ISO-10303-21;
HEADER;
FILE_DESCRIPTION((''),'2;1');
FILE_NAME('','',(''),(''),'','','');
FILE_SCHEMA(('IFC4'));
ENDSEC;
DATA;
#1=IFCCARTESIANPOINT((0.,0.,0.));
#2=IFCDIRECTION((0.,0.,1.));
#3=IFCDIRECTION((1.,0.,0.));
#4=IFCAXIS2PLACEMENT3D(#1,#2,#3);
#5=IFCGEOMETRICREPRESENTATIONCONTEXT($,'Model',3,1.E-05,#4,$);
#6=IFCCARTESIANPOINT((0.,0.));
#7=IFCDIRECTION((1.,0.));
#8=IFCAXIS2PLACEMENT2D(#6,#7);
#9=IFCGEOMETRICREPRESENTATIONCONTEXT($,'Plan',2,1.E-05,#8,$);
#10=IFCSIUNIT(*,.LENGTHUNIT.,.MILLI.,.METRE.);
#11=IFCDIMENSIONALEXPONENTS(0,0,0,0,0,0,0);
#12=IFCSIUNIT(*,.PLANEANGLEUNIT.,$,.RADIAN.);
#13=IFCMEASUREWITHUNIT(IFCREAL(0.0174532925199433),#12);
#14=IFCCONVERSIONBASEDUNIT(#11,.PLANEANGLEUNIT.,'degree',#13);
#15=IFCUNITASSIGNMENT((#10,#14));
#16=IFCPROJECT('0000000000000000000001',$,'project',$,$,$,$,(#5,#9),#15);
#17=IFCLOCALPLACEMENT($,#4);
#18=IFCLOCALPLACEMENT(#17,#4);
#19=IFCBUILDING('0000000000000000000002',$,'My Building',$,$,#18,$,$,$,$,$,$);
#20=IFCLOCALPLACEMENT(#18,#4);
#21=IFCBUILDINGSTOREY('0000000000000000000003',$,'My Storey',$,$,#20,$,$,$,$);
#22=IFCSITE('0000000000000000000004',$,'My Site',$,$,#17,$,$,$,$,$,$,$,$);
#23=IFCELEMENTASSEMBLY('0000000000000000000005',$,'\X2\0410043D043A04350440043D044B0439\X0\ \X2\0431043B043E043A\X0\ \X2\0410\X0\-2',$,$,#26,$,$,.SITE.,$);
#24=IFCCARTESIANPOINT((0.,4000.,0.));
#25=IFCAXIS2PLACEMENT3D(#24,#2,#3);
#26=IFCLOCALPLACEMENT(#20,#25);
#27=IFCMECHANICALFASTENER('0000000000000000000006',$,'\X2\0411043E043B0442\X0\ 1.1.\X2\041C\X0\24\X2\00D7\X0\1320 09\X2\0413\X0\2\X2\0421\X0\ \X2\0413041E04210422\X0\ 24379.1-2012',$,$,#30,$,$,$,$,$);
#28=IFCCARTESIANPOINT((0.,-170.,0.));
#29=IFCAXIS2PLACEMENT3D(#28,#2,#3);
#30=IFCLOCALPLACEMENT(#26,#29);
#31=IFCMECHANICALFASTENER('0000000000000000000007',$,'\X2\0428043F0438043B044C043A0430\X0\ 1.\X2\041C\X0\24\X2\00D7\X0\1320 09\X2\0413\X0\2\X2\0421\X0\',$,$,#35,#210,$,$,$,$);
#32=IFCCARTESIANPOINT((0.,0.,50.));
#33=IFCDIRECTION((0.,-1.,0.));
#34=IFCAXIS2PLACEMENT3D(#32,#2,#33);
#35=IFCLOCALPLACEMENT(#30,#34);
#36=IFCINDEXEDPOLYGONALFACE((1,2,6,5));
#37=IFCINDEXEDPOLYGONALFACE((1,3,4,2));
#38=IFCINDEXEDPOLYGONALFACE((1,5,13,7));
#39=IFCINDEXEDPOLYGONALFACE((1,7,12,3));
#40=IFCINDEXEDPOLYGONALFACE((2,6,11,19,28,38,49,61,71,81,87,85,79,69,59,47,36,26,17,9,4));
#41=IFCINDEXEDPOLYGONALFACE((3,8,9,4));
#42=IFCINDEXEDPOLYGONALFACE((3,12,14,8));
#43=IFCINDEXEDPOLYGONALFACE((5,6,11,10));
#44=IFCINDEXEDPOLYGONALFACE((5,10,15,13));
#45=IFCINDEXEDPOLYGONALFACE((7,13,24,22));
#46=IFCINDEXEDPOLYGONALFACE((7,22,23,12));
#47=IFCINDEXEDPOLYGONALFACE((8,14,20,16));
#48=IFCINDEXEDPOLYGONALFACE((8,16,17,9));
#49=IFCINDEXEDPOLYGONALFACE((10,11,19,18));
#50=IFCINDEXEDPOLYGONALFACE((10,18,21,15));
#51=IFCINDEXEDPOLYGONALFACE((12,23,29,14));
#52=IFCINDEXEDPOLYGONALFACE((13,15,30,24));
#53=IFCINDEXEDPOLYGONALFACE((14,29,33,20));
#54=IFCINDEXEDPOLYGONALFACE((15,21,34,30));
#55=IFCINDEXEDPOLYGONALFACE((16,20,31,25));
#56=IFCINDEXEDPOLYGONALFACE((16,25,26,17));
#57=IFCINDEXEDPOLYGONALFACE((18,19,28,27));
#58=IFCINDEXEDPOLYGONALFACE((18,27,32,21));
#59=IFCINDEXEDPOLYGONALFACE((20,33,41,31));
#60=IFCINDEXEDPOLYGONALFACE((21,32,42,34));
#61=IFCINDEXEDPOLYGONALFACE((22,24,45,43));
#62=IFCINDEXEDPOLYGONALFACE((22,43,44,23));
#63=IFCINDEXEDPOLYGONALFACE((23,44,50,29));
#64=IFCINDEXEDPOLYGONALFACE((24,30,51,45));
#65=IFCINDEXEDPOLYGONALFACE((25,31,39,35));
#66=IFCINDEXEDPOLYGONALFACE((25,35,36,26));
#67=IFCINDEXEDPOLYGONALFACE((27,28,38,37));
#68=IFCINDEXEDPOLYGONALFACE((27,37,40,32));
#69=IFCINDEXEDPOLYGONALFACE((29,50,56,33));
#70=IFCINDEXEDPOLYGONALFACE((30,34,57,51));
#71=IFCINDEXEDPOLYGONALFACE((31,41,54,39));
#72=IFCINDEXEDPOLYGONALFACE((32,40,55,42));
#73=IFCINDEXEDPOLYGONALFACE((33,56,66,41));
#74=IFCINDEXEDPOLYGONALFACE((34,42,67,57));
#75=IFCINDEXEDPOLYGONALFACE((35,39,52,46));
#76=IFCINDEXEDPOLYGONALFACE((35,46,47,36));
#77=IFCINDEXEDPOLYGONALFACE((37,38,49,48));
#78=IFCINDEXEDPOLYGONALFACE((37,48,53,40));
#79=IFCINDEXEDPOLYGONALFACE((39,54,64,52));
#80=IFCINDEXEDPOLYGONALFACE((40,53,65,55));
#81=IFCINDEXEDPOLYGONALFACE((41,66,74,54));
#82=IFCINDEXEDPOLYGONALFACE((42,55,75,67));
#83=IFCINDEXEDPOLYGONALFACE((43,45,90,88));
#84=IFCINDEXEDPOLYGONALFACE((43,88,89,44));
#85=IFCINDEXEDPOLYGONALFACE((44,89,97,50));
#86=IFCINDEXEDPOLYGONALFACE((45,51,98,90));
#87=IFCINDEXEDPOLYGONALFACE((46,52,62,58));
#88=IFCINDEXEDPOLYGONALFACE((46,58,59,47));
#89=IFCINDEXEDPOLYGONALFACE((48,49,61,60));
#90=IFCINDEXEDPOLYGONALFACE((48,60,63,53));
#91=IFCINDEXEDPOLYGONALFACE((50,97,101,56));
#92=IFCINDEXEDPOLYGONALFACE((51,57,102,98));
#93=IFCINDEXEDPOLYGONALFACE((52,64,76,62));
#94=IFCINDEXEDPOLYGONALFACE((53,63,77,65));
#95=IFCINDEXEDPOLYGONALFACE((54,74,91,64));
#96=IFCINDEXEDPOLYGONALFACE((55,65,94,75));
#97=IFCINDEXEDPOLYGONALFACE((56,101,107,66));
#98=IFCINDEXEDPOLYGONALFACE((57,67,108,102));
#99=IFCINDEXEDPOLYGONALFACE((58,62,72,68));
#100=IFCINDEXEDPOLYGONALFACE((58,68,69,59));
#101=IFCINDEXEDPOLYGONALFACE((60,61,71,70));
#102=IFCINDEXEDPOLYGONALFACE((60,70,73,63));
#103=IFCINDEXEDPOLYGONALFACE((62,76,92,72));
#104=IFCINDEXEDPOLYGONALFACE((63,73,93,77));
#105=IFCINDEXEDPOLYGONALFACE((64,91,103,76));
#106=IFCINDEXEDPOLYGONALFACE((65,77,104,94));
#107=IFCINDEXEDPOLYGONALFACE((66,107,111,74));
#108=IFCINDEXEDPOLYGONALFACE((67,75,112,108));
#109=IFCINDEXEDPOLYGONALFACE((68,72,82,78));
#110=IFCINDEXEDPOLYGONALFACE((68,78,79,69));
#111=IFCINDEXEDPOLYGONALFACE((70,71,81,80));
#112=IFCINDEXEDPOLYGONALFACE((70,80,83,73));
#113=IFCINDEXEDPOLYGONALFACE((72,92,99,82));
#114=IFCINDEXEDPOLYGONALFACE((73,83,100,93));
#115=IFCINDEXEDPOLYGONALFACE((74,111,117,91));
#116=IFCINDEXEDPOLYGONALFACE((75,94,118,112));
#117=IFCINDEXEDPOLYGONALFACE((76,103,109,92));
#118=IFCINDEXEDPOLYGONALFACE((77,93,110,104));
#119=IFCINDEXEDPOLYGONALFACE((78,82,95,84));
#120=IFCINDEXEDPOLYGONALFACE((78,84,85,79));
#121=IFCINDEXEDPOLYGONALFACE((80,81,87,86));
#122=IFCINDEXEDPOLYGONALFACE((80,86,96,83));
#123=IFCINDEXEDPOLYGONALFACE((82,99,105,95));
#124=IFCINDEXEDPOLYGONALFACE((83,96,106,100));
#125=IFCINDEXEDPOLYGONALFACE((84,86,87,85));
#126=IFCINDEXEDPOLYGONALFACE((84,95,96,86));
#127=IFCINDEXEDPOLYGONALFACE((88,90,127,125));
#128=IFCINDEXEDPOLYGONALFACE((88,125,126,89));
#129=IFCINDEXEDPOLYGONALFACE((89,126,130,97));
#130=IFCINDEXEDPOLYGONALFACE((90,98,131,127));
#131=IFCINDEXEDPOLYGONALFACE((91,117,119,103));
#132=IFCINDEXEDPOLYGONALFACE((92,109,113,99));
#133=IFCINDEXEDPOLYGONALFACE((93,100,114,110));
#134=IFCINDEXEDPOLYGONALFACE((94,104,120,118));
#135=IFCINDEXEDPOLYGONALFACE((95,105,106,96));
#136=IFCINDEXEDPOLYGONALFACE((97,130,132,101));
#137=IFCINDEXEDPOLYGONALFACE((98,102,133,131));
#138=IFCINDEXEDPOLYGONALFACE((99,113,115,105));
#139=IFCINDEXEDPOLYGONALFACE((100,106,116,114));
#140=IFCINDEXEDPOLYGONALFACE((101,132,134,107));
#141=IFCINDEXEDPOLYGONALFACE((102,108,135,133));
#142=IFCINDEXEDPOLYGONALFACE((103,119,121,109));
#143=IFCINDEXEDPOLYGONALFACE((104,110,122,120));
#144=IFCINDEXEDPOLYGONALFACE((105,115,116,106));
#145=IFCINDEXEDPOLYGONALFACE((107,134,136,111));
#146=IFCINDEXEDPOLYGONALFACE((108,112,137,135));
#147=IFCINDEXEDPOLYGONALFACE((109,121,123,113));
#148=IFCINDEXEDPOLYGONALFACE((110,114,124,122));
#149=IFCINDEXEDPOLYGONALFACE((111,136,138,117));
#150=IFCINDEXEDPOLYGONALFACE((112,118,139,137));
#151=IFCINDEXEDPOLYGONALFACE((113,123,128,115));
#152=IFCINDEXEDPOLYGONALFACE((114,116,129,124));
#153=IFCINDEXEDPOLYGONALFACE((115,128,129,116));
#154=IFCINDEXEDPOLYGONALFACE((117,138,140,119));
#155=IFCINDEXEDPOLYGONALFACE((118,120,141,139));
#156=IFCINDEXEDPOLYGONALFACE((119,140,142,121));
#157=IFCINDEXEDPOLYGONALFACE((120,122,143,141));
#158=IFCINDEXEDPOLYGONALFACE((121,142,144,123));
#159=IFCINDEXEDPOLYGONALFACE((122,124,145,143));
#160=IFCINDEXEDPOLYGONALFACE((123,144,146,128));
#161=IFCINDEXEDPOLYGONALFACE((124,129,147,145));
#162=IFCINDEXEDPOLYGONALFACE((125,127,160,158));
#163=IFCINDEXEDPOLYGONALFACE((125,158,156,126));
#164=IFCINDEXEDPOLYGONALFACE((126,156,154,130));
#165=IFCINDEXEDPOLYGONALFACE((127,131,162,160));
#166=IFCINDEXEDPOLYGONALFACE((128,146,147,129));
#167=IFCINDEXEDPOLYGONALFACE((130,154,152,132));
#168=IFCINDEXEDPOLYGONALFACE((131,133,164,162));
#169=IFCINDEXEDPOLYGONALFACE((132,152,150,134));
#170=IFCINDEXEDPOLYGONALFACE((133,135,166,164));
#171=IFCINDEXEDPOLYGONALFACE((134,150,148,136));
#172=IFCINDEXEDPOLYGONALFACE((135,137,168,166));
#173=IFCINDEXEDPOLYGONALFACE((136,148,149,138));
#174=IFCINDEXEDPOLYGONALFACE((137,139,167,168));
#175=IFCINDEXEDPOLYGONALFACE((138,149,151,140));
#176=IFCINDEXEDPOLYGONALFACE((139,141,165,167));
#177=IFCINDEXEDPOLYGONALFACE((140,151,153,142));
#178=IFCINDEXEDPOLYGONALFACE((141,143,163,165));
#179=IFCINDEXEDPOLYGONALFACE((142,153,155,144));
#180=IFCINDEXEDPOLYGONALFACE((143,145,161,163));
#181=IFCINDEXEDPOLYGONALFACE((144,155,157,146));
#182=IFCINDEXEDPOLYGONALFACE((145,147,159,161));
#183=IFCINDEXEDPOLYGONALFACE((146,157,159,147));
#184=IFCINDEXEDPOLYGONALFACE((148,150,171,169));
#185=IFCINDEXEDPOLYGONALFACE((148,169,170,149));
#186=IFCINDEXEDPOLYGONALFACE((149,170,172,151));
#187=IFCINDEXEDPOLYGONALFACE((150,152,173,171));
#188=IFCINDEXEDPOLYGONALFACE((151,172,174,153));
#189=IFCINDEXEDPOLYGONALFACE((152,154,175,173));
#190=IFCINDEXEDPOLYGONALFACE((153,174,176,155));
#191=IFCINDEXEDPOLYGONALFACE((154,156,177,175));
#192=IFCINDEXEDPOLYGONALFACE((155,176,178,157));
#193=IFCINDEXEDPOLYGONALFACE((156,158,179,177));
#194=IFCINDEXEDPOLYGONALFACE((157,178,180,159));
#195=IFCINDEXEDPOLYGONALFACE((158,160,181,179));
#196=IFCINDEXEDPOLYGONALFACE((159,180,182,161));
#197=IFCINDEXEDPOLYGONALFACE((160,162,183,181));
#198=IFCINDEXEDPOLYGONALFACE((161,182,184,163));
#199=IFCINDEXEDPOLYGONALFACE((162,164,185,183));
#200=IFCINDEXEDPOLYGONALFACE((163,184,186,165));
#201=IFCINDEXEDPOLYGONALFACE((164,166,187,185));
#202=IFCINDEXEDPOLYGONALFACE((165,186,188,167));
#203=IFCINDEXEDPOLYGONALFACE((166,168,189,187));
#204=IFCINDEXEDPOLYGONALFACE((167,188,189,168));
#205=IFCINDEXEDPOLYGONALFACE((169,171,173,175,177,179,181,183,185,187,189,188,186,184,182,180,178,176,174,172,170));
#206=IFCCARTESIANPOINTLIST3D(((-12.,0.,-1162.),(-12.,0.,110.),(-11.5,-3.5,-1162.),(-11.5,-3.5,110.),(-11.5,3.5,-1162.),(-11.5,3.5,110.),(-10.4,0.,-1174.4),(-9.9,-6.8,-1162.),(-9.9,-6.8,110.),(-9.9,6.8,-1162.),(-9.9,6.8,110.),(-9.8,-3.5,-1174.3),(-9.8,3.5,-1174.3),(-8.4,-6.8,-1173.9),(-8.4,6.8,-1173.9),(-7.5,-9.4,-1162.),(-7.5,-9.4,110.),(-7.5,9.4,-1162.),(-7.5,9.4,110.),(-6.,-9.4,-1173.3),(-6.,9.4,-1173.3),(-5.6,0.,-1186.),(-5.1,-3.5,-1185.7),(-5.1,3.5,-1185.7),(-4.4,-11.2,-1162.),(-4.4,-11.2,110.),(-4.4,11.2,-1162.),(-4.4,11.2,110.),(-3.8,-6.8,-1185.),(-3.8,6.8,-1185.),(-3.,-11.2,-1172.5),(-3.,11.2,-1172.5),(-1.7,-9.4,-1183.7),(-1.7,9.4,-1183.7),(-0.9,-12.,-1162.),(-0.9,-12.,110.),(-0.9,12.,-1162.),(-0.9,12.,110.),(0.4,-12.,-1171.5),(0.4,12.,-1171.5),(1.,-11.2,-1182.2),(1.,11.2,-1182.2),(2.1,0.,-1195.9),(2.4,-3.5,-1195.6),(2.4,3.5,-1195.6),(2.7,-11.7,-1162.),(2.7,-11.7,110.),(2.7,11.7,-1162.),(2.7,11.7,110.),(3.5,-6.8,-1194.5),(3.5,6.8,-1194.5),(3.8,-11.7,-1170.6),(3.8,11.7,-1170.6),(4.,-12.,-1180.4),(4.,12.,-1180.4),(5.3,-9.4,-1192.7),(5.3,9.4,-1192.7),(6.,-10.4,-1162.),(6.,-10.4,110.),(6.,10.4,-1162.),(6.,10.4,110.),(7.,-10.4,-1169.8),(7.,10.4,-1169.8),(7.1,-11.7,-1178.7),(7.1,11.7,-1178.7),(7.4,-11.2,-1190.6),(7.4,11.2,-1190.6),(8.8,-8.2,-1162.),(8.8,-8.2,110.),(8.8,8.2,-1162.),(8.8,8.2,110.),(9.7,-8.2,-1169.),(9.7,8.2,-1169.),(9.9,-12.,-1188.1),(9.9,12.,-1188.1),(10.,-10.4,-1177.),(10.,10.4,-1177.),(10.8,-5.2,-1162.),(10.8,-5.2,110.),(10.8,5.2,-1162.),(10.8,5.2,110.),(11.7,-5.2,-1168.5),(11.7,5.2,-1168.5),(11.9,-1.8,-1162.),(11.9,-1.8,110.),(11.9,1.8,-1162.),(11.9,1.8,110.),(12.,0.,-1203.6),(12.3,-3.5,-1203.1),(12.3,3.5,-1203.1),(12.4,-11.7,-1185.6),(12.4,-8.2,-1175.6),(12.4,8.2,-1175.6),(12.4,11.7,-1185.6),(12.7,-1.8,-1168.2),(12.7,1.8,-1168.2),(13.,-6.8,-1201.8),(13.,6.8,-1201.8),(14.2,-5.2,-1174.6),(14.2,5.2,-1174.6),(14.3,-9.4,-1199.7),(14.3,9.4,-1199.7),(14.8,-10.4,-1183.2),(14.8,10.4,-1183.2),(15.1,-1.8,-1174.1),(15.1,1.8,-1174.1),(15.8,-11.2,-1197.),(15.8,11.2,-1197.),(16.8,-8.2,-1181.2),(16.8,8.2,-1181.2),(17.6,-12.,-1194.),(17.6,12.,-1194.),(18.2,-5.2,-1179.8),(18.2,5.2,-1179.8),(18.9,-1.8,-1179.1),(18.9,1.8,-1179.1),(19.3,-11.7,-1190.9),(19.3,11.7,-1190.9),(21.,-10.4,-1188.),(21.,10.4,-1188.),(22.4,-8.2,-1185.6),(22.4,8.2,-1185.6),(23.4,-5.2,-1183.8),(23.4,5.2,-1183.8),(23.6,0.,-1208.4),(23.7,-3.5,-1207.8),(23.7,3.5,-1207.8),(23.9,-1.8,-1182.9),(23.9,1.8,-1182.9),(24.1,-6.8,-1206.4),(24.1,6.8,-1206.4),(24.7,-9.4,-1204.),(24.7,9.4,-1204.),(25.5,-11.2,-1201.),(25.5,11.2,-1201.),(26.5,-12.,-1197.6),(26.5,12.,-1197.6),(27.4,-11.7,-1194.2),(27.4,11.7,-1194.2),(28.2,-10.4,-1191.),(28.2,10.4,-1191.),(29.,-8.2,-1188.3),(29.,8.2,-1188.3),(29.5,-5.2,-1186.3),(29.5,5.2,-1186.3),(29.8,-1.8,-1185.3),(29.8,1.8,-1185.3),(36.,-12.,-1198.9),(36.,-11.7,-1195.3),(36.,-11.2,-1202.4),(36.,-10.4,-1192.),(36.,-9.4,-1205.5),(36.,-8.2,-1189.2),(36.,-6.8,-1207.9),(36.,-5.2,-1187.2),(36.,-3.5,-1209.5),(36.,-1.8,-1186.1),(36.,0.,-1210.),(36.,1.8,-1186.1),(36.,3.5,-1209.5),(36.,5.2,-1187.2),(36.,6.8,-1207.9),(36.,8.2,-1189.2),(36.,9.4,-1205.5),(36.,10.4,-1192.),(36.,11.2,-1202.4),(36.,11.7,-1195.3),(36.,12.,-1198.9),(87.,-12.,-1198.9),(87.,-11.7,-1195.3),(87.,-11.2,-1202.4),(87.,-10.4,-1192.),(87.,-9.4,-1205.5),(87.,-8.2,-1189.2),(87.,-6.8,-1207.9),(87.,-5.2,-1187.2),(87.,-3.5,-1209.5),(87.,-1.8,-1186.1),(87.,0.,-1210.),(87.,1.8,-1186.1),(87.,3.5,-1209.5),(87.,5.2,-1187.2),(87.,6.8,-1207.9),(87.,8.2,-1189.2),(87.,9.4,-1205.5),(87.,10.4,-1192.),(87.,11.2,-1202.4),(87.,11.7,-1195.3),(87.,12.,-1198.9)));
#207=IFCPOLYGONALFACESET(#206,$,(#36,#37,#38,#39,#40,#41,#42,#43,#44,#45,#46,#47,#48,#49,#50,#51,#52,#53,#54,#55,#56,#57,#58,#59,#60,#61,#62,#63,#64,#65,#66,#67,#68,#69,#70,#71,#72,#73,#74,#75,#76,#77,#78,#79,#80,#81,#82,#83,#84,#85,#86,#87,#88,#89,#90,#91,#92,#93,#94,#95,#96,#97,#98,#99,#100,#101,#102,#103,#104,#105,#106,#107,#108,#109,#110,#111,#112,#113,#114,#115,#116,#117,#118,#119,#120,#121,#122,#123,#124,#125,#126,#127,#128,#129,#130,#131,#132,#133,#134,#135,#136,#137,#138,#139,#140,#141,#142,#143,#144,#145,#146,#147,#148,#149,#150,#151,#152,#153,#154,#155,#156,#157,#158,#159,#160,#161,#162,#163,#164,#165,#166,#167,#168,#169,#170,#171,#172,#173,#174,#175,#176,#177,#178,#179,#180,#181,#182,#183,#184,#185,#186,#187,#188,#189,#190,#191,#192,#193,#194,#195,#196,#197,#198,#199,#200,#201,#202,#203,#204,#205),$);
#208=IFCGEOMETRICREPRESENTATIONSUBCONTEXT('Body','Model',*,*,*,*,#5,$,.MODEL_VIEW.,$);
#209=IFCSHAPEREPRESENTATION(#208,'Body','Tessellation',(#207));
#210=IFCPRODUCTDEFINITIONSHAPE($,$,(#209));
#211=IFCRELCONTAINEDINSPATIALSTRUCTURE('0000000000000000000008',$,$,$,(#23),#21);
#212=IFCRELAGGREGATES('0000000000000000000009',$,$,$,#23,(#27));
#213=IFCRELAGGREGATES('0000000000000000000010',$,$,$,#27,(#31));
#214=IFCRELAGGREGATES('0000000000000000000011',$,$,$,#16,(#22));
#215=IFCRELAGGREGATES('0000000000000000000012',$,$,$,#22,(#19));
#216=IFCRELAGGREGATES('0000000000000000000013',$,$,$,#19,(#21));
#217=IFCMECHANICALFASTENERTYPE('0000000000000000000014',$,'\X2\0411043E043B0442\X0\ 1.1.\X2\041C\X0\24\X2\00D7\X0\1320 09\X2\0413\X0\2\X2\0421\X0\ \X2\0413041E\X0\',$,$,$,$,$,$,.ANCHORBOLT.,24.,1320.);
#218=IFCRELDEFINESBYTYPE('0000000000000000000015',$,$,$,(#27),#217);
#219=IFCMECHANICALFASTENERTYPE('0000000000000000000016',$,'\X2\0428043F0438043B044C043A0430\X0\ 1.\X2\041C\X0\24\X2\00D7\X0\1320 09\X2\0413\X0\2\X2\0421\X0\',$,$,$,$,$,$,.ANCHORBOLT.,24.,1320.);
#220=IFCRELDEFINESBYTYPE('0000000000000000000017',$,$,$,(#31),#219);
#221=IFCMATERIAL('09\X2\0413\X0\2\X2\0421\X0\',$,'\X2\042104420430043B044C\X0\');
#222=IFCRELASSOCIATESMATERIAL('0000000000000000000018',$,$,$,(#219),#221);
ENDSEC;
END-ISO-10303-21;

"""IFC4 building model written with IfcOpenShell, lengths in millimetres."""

from ifc_helpers import new_model, entity, si_unit, converted_unit, frame, origin_with_axes, origin_2d_with_axis, place, context, subcontext, project, spatial, source, transform, mapped, material, type_object, type_shapes, element, aggregate, save


model = new_model("IFC4")

# Units and contexts
model_context = context("Model", 3, precision=1e-05, world=origin_with_axes())
plan_context = context("Plan", 2, precision=1e-05, world=origin_2d_with_axis())
body_context = subcontext(model_context, "Body", "Model", "MODEL_VIEW")
ifc_project = project(units=[si_unit("LENGTHUNIT", "METRE", prefix="MILLI"), converted_unit("PLANEANGLEUNIT", "degree", entity("IfcReal", 0.0174532925199433), si_unit("PLANEANGLEUNIT", "RADIAN"), dimensions=[0, 0, 0, 0, 0, 0, 0])], contexts=[model_context, plan_context])

# Site, building, storey
site_placement = place(None, origin_with_axes())
site = spatial("IfcSite", under=ifc_project, at=site_placement, Name="My Site")
building_placement = place(site_placement, origin_with_axes())
building = spatial("IfcBuilding", under=site, at=building_placement, Name="My Building")
storey_placement = place(building_placement, origin_with_axes())
storey = spatial("IfcBuildingStorey", under=building, at=storey_placement, Name="My Storey")

# Element assembly, mechanical fasteners
ifc_material_1 = material(Name="09Г2С", Category="Сталь")
mechanical_fastener_type_1 = type_object("IfcMechanicalFastenerType", Name="Шпилька 1.М24×1320 09Г2С", NominalDiameter=24.0, NominalLength=1320.0, PredefinedType="ANCHORBOLT", material=ifc_material_1)
shared_shape_1 = source(frame((0.0, 0.0, 110.0), z_axis=(0.0, 0.0, 1.0), x_axis=(1.0, 0.0, 0.0)), body_context, "Body", "AdvancedSweptSolid", [
    entity("IfcSweptDiskSolid", entity("IfcIndexedPolyCurve", entity("IfcCartesianPointList3D", [[0.0, 0.0, 0.0], [0.0, 0.0, -1272.0], [10.5, 0.0, -1297.5], [36.0, 0.0, -1308.0], [87.0, 0.0, -1308.0]]), [entity("IfcLineIndex", [1, 2]), entity("IfcArcIndex", [2, 3, 4]), entity("IfcLineIndex", [4, 5])]), 12.0),
])
type_shapes(mechanical_fastener_type_1, [shared_shape_1])
mechanical_fastener_type_2 = type_object("IfcMechanicalFastenerType", Name="Болт 1.1.М24×1320 09Г2С ГО", NominalDiameter=24.0, NominalLength=1320.0, PredefinedType="ANCHORBOLT")
assembly_1_placement = place(storey_placement, frame((0.0, 4000.0, 0.0), z_axis=(0.0, 0.0, 1.0), x_axis=(1.0, 0.0, 0.0)))
assembly_1 = element("IfcElementAssembly", 1, at=assembly_1_placement, inside=storey, Name="Анкерный блок А-2", AssemblyPlace="SITE")
mechanical_fastener_1_placement = place(assembly_1_placement, frame((0.0, -170.0, 0.0), z_axis=(0.0, 0.0, 1.0), x_axis=(1.0, 0.0, 0.0)))
mechanical_fastener_1 = element("IfcMechanicalFastener", 2, at=mechanical_fastener_1_placement, type_object=mechanical_fastener_type_2, Name="Болт 1.1.М24×1320 09Г2С ГОСТ 24379.1-2012")
mechanical_fastener_2_placement = place(mechanical_fastener_1_placement, frame((0.0, 0.0, 50.0), z_axis=(0.0, 0.0, 1.0), x_axis=(0.0, -1.0, 0.0)))
mechanical_fastener_2 = element("IfcMechanicalFastener", 3, at=mechanical_fastener_2_placement, type_object=mechanical_fastener_type_1, Name="Шпилька 1.М24×1320 09Г2С", context=body_context, shape_type="MappedRepresentation", body=[
    mapped(shared_shape_1, transform((0.0, 0.0, 0.0), x_axis=(1.0, 0.0, 0.0), y_axis=(0.0, 1.0, 0.0), z_axis=(0.0, 0.0, 1.0), scale=1.0)),
])
aggregate(assembly_1, [mechanical_fastener_1])

aggregate(mechanical_fastener_1, [mechanical_fastener_2])

save(model, "model.ifc")
